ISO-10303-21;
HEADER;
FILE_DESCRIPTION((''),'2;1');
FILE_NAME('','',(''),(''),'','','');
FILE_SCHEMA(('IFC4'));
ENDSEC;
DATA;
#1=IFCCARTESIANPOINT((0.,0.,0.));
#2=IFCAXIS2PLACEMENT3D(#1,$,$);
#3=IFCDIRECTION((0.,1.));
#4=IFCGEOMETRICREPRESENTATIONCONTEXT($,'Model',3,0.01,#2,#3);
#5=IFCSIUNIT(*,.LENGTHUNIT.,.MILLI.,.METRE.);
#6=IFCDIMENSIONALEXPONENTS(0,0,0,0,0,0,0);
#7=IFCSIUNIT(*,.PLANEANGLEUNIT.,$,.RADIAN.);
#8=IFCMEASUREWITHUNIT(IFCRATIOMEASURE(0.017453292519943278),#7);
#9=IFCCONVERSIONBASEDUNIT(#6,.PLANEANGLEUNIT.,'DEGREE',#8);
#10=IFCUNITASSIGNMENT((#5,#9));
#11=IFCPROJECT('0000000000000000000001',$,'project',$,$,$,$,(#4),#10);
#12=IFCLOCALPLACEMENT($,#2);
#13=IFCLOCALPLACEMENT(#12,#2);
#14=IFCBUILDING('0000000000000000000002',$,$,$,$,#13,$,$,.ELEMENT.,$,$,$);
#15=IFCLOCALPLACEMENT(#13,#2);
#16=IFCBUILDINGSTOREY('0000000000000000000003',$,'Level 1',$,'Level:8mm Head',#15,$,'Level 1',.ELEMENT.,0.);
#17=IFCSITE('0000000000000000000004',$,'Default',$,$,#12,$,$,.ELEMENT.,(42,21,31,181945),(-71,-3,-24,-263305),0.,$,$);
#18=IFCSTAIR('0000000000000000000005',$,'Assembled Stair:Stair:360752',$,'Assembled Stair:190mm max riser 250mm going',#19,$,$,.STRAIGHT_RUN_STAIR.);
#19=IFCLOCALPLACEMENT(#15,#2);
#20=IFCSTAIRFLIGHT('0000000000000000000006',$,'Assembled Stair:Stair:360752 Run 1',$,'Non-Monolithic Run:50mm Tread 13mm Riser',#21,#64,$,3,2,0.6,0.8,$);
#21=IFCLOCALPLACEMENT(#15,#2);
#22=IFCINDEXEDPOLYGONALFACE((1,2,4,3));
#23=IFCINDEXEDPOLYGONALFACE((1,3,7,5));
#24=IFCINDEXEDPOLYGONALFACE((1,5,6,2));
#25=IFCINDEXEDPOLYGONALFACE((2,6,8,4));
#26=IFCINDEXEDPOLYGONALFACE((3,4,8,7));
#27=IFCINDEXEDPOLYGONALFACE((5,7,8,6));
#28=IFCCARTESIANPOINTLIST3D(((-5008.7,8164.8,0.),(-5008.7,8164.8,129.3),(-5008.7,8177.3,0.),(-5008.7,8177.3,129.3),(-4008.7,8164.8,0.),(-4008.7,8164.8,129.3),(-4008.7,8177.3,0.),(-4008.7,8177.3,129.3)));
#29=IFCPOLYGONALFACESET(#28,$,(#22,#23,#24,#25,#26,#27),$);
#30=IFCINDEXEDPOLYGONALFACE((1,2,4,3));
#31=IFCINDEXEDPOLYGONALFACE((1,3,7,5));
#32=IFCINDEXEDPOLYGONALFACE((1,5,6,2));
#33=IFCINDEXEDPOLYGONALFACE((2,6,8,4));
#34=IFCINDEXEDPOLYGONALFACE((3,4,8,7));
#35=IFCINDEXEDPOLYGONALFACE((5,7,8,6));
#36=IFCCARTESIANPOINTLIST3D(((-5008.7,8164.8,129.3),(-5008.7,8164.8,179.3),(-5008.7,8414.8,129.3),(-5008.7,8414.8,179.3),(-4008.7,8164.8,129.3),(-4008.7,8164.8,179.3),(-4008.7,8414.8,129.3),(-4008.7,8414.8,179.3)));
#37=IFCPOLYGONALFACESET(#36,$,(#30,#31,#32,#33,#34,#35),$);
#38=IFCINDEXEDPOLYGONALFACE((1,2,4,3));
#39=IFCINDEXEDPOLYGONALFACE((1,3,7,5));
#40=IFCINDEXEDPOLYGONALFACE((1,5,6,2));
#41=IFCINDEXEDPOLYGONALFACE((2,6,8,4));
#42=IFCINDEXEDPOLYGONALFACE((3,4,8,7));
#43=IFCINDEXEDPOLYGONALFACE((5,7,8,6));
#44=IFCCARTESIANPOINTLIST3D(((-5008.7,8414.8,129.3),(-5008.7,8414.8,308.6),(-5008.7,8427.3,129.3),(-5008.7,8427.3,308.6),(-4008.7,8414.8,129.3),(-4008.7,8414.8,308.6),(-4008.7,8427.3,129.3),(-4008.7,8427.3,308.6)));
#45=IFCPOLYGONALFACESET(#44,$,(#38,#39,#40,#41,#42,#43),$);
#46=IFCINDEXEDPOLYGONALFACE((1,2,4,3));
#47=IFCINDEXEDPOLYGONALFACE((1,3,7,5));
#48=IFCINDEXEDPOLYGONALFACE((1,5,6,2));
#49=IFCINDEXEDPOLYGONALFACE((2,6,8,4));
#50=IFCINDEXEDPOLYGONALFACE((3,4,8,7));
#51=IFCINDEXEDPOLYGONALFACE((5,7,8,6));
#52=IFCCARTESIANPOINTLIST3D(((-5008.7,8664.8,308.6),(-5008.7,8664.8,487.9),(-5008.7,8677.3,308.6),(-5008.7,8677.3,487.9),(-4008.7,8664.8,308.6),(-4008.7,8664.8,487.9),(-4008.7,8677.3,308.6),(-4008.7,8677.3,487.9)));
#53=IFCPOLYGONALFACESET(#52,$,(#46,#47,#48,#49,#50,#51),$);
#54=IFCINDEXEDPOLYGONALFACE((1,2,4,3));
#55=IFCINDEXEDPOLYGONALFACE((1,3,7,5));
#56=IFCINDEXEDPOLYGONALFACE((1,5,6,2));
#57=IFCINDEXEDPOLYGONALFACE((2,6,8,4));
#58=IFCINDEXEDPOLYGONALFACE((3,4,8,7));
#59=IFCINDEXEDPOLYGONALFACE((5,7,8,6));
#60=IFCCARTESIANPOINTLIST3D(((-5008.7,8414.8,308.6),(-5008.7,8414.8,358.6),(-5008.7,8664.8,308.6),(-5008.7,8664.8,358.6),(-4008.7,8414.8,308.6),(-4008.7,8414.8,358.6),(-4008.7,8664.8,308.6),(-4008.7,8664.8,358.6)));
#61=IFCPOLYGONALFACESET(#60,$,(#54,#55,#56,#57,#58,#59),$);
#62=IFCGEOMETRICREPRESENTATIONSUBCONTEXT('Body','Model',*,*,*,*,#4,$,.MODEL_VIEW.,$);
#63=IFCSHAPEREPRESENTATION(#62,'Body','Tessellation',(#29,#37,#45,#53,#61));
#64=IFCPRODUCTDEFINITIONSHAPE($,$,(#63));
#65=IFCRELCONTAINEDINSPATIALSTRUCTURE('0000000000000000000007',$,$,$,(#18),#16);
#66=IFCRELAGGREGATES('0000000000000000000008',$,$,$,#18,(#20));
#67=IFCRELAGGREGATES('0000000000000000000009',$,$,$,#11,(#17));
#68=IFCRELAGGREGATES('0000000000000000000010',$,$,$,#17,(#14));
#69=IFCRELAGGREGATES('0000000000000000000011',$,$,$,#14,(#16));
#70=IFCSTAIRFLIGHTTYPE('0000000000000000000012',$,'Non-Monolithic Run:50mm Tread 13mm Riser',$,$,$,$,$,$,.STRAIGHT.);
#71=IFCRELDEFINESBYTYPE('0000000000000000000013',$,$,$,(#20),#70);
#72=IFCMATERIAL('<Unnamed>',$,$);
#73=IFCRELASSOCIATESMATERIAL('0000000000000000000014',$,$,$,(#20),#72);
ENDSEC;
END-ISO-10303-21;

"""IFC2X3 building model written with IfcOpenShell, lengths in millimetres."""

from ifc_helpers import new_model, entity, si_unit, converted_unit, direction, frame, frame_2d, origin, place, context, subcontext, project, spatial, rectangle, extrude, material, type_object, element, aggregate, save


model = new_model("IFC2X3")

# Units and contexts
model_context = context("Model", 3, precision=0.01, world=origin(), true_north=direction((0.0, 1.0)))
body_context = subcontext(model_context, "Body", "Model", "MODEL_VIEW")
ifc_project = project(units=[si_unit("LENGTHUNIT", "METRE", prefix="MILLI"), converted_unit("PLANEANGLEUNIT", "DEGREE", entity("IfcRatioMeasure", 0.017453292519943278), si_unit("PLANEANGLEUNIT", "RADIAN"), dimensions=[0, 0, 0, 0, 0, 0, 0])], contexts=[model_context])

# Site, building, storey
site_placement = place(None, origin())
site = spatial("IfcSite", under=ifc_project, at=site_placement, Name="Default", CompositionType="ELEMENT", RefLatitude=(42, 21, 31, 181945), RefLongitude=(-71, -3, -24, -263305), RefElevation=0.0)
building_placement = place(site_placement, origin())
building = spatial("IfcBuilding", under=site, at=building_placement, CompositionType="ELEMENT")
storey_placement = place(building_placement, origin())
storey = spatial("IfcBuildingStorey", under=building, at=storey_placement, Name="Level 1", ObjectType="Level:8mm Head", LongName="Level 1", CompositionType="ELEMENT", Elevation=0.0)

# Stair
stair_placement = place(storey_placement, origin())
stair = element("IfcStair", 1, at=stair_placement, inside=storey, Name="Assembled Stair:Stair:360752", ObjectType="Assembled Stair:190mm max riser 250mm going", ShapeType="STRAIGHT_RUN_STAIR")
ifc_material_1 = material(Name="<Unnamed>")

# Stair flight
stair_flight_type = type_object("IfcStairFlightType", Name="Non-Monolithic Run:50mm Tread 13mm Riser", PredefinedType="STRAIGHT")
stair_flight_placement = place(stair_placement, origin())
stair_flight = element("IfcStairFlight", 2, at=stair_flight_placement, type_object=stair_flight_type, material=ifc_material_1, Name="Assembled Stair:Stair:360752 Run 1", ObjectType="Non-Monolithic Run:50mm Tread 13mm Riser", NumberOfRiser=3, NumberOfTreads=2, RiserHeight=0.6, TreadLength=0.8, context=body_context, shape_type="SweptSolid", body=[
    extrude(rectangle(XDim=1000.0, YDim=12.5, at=frame_2d((0.0, 0.0), x_axis=(1.0, 0.0))), frame((-4508.7, 8171.0, 0.0), z_axis=(0.0, 0.0, 1.0), x_axis=(-1.0, 0.0, 0.0)), (0.0, 0.0, 1.0), 129.3),
    extrude(rectangle(XDim=250.0, YDim=1000.0, at=frame_2d((0.0, 0.0), x_axis=(1.0, 0.0))), frame((-4508.7, 8289.8, 129.3), z_axis=(0.0, 0.0, 1.0), x_axis=(0.0, -1.0, 0.0)), (0.0, 0.0, 1.0), 50.0),
    extrude(rectangle(XDim=1000.0, YDim=12.5, at=frame_2d((0.0, 0.0), x_axis=(1.0, 0.0))), frame((-4508.7, 8421.0, 129.3), z_axis=(0.0, 0.0, 1.0), x_axis=(-1.0, 0.0, 0.0)), (0.0, 0.0, 1.0), 179.3),
    extrude(rectangle(XDim=1000.0, YDim=12.5, at=frame_2d((0.0, 0.0), x_axis=(1.0, 0.0))), frame((-4508.7, 8671.0, 308.6), z_axis=(0.0, 0.0, 1.0), x_axis=(-1.0, 0.0, 0.0)), (0.0, 0.0, 1.0), 179.3),
    extrude(rectangle(XDim=250.0, YDim=1000.0, at=frame_2d((0.0, 0.0), x_axis=(1.0, 0.0))), frame((-4508.7, 8539.8, 308.6), z_axis=(0.0, 0.0, 1.0), x_axis=(0.0, -1.0, 0.0)), (0.0, 0.0, 1.0), 50.0),
])
aggregate(stair, [stair_flight])

save(model, "model.ifc")
